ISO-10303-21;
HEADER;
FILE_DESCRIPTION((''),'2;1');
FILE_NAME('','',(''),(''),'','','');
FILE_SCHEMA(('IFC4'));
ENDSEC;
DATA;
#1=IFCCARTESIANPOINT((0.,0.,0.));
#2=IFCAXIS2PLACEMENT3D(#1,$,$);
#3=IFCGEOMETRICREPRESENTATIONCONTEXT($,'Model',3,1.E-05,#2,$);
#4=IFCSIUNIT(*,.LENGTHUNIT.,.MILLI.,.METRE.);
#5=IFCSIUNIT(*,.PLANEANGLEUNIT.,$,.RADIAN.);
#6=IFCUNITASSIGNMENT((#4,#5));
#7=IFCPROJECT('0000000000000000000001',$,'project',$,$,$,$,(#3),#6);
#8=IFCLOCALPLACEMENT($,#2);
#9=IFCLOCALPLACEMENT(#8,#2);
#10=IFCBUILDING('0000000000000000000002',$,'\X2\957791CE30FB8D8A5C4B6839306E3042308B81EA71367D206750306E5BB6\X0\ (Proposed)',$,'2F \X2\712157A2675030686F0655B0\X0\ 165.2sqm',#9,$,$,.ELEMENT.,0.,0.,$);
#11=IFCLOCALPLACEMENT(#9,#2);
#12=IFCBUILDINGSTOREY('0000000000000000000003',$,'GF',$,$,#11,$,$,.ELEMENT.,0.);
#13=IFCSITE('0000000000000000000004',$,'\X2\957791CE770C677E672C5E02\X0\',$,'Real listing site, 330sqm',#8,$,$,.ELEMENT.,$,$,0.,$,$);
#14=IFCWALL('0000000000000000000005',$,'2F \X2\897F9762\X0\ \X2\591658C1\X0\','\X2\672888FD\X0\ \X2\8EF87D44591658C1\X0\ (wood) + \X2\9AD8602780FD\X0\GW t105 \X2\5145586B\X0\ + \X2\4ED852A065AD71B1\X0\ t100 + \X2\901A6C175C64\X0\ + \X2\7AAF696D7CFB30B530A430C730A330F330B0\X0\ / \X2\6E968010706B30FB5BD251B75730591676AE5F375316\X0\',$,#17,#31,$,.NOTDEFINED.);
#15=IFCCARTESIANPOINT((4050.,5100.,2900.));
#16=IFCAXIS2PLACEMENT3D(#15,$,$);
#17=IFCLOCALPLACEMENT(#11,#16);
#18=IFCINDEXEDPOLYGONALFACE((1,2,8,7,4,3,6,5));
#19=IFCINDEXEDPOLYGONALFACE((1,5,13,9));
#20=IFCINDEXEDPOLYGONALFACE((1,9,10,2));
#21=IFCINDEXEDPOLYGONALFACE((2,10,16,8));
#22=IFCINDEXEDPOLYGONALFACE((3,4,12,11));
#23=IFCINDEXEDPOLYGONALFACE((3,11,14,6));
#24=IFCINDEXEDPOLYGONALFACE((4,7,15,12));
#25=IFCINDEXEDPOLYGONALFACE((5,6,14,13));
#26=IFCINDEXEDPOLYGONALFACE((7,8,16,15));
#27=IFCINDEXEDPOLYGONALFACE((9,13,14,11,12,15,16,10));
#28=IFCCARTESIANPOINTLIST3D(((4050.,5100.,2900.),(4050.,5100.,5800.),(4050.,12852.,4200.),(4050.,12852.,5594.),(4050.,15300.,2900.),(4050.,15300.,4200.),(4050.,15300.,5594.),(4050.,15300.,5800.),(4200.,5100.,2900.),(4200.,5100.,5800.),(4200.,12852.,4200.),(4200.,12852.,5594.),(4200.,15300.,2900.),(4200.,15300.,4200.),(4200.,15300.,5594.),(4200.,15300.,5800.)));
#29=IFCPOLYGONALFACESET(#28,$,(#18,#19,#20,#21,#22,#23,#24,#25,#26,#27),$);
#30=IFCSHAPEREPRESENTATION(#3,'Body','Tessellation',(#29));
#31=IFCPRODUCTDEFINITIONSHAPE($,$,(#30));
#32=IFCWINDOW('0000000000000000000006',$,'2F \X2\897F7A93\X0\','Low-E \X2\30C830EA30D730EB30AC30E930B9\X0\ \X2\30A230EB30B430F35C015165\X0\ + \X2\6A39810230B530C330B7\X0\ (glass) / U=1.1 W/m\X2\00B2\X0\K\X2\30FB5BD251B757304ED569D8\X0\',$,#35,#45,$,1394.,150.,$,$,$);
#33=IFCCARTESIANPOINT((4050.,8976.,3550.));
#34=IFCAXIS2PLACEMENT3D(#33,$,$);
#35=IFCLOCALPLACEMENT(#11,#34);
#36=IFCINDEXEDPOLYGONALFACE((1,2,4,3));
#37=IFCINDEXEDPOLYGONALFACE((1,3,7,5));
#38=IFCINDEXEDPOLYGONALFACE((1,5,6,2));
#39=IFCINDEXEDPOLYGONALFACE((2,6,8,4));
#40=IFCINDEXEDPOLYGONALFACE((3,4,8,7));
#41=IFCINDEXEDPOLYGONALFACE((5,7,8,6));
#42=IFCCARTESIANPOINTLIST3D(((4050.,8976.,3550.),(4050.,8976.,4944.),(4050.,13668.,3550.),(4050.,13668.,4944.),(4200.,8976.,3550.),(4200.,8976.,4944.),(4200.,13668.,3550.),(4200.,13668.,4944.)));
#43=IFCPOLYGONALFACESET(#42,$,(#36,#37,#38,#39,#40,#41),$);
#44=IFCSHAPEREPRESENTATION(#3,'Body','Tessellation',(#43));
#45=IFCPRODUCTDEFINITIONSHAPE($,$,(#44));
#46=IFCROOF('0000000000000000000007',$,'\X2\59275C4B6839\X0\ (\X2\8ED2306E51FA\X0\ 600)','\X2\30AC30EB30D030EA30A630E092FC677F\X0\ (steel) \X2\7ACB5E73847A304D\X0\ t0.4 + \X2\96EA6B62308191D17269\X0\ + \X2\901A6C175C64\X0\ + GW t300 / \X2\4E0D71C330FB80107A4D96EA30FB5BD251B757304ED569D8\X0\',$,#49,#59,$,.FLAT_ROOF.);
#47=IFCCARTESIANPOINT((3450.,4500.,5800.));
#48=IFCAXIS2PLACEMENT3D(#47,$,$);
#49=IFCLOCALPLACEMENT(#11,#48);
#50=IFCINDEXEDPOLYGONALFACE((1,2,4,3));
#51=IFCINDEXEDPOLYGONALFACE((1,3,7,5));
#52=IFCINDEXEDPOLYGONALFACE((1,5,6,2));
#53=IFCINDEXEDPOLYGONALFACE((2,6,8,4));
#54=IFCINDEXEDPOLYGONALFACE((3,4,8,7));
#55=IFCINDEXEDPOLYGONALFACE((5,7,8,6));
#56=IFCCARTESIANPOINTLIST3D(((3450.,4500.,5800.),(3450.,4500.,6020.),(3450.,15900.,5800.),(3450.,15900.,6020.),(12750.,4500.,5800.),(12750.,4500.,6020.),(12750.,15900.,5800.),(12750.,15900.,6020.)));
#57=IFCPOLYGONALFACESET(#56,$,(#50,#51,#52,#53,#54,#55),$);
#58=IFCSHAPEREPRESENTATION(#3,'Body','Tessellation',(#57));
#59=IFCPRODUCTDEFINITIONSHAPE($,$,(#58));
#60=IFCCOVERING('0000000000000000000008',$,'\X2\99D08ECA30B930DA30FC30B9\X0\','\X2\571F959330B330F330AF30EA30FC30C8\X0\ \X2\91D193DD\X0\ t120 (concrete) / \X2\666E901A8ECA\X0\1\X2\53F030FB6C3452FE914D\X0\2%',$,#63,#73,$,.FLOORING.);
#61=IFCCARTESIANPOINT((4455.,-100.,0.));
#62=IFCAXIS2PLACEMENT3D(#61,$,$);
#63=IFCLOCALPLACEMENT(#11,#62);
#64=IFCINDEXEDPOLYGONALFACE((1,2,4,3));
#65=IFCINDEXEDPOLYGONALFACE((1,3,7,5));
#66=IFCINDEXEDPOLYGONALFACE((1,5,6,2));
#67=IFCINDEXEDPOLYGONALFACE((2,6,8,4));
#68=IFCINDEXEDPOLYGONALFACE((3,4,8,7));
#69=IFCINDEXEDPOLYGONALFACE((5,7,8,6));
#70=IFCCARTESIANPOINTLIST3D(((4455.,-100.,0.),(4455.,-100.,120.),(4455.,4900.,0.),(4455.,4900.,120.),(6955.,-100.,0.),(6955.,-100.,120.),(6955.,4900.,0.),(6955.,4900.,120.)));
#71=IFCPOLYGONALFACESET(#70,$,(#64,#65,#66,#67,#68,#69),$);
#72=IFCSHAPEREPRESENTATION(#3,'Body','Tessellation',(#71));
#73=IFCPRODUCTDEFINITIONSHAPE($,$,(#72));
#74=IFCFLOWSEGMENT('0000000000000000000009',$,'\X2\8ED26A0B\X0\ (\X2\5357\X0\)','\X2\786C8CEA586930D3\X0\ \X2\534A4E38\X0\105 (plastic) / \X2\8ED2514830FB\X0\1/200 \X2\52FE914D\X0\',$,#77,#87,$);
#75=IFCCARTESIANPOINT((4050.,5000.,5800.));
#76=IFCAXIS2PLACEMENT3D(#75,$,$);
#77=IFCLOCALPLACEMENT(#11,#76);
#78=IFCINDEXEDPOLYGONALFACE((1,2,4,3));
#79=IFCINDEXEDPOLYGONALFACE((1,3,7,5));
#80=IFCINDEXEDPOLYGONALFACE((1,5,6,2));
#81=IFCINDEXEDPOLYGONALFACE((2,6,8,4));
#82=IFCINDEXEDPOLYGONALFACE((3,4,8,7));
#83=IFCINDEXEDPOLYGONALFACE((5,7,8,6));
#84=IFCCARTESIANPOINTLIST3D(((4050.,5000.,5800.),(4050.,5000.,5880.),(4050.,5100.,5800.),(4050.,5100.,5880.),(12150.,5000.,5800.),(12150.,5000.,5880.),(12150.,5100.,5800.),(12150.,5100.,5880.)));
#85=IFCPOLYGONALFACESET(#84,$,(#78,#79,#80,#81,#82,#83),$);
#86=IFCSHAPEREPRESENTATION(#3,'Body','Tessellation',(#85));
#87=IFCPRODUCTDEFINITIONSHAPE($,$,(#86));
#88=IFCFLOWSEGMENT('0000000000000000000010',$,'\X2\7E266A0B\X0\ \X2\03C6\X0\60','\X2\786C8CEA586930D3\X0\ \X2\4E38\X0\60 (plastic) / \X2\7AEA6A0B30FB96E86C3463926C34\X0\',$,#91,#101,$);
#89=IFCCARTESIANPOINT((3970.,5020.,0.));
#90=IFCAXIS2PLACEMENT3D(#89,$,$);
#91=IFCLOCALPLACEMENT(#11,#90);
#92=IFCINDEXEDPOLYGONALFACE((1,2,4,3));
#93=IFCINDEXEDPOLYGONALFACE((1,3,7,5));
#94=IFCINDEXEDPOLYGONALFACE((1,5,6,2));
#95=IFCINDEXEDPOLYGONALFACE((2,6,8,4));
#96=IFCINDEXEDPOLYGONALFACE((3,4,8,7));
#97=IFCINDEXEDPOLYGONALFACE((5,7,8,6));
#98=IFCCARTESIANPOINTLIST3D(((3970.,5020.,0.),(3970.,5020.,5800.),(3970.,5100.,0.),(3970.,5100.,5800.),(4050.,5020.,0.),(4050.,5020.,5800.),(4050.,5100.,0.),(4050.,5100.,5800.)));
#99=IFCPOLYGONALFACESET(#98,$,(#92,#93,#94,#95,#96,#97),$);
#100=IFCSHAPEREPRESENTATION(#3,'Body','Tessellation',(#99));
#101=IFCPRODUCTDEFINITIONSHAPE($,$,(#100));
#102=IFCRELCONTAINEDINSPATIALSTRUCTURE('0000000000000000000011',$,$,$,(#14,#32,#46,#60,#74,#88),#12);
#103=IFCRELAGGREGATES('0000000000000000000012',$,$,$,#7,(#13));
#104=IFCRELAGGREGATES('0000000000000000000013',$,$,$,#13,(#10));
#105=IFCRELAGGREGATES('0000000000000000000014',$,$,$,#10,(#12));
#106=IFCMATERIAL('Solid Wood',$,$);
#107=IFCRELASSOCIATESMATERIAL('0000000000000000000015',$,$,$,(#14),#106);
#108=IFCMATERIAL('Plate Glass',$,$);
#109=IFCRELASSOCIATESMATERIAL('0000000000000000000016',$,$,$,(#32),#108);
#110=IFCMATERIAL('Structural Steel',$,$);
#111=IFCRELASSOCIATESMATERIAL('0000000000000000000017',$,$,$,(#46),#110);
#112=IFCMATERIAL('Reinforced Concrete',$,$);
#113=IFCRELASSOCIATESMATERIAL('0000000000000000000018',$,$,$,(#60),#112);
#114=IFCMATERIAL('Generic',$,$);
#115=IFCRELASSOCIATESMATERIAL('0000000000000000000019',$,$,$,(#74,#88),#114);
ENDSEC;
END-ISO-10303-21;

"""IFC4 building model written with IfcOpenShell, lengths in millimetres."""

from ifc_helpers import new_model, si_unit, frame, frame_2d, origin, place, context, project, spatial, rectangle, extrude, material, element, fill, save


model = new_model("IFC4")

# Units and contexts
model_context = context("Model", 3, precision=1e-05, world=origin())
ifc_project = project(units=[si_unit("LENGTHUNIT", "METRE", prefix="MILLI"), si_unit("PLANEANGLEUNIT", "RADIAN")], contexts=[model_context])

# Site, building, storey
site_placement = place(None, origin())
site = spatial("IfcSite", under=ifc_project, at=site_placement, Name="長野県松本市", ObjectType="Real listing site, 330sqm", CompositionType="ELEMENT", RefElevation=0.0)
building_placement = place(site_placement, origin())
building = spatial("IfcBuilding", under=site, at=building_placement, Name="長野・越屋根のある自然素材の家 (Proposed)", ObjectType="2F 無垢材と漆喰 165.2sqm", CompositionType="ELEMENT", ElevationOfRefHeight=0.0, ElevationOfTerrain=0.0)
storey_placement = place(building_placement, origin())
storey = spatial("IfcBuildingStorey", under=building, at=storey_placement, Name="GF", CompositionType="ELEMENT", Elevation=0.0)

# Shared definitions
ifc_material_1 = material(Name="Solid Wood")

# Shared definitions
ifc_material_2 = material(Name="Reinforced Concrete")

# Shared definitions
ifc_material_3 = material(Name="Plate Glass")

# Wall, opening, window
wall_1_placement = place(storey_placement, frame((4050.0, 5100.0, 2900.0)))
wall_1 = element("IfcWall", 1, at=wall_1_placement, inside=storey, material=ifc_material_1, Name="2F 西面 外壁", Description="木製 軸組外壁 (wood) + 高性能GW t105 充填 + 付加断熱 t100 + 通気層 + 窯業系サイディング / 準耐火・寒冷地外皮強化", PredefinedType="NOTDEFINED", context=model_context, shape_type="SweptSolid", body=[
    extrude(rectangle(XDim=150.0, YDim=10200.0, at=frame_2d((75.0, 5100.0))), frame((4050.0, 5100.0, 2900.0)), (0.0, 0.0, 1.0), 2900.0),
])
opening_1_placement = place(storey_placement, frame((4050.0, 8976.0, 3550.0)))
opening_1 = element("IfcOpeningElement", 2, at=opening_1_placement, cuts=wall_1, PredefinedType="NOTDEFINED", context=model_context, shape_type="SweptSolid", body=[
    extrude(rectangle(XDim=150.0, YDim=4692.0, at=frame_2d((75.0, 2346.0))), frame((4050.0, 8976.0, 3550.0)), (0.0, 0.0, 1.0), 1394.0),
])
window_1_placement = place(storey_placement, frame((4050.0, 8976.0, 3550.0)))
window_1 = element("IfcWindow", 3, at=window_1_placement, inside=storey, material=ifc_material_3, Name="2F 西窓", Description="Low-E トリプルガラス アルゴン封入 + 樹脂サッシ (glass) / U=1.1 W/m²K・寒冷地仕様", OverallHeight=1394.0, OverallWidth=150.0, context=model_context, shape_type="SweptSolid", body=[
    extrude(rectangle(XDim=150.0, YDim=4692.0, at=frame_2d((75.0, 2346.0))), frame((4050.0, 8976.0, 3550.0)), (0.0, 0.0, 1.0), 1394.0),
])
fill(opening_1, window_1)

# Roof
ifc_material_4 = material(Name="Structural Steel")
roof_placement = place(storey_placement, frame((3450.0, 4500.0, 5800.0)))
element("IfcRoof", 4, at=roof_placement, inside=storey, material=ifc_material_4, Name="大屋根 (軒の出 600)", Description="ガルバリウム鋼板 (steel) 立平葺き t0.4 + 雪止め金物 + 通気層 + GW t300 / 不燃・耐積雪・寒冷地仕様", PredefinedType="FLAT_ROOF", context=model_context, shape_type="SweptSolid", body=[
    extrude(rectangle(XDim=9300.0, YDim=11400.0, at=frame_2d((4650.0, 5700.0))), frame((3450.0, 4500.0, 5800.0)), (0.0, 0.0, 1.0), 220.0),
])

# Covering
covering_placement = place(storey_placement, frame((4455.0, -100.0, 0.0)))
element("IfcCovering", 5, at=covering_placement, inside=storey, material=ifc_material_2, Name="駐車スペース", Description="土間コンクリート 金鏝 t120 (concrete) / 普通車1台・水勾配2%", PredefinedType="FLOORING", context=model_context, shape_type="SweptSolid", body=[
    extrude(rectangle(XDim=2500.0, YDim=5000.0, at=frame_2d((1250.0, 2500.0))), frame((4455.0, -100.0, 0.0)), (0.0, 0.0, 1.0), 120.0),
])

# Flow segments
ifc_material_5 = material(Name="Generic")
flow_segment_1_placement = place(storey_placement, frame((4050.0, 5000.0, 5800.0)))
element("IfcFlowSegment", 6, at=flow_segment_1_placement, inside=storey, material=ifc_material_5, Name="軒樋 (南)", Description="硬質塩ビ 半丸105 (plastic) / 軒先・1/200 勾配", context=model_context, shape_type="SweptSolid", body=[
    extrude(rectangle(XDim=8100.0, YDim=100.0, at=frame_2d((4050.0, 50.0))), frame((4050.0, 5000.0, 5800.0)), (0.0, 0.0, 1.0), 80.0),
])
flow_segment_2_placement = place(storey_placement, frame((3970.0, 5020.0, 0.0)))
element("IfcFlowSegment", 7, at=flow_segment_2_placement, inside=storey, material=ifc_material_5, Name="縦樋 φ60", Description="硬質塩ビ 丸60 (plastic) / 竪樋・雨水排水", context=model_context, shape_type="SweptSolid", body=[
    extrude(rectangle(XDim=80.0, YDim=80.0, at=frame_2d((40.0, 40.0))), frame((3970.0, 5020.0, 0.0)), (0.0, 0.0, 1.0), 5800.0),
])

save(model, "model.ifc")
